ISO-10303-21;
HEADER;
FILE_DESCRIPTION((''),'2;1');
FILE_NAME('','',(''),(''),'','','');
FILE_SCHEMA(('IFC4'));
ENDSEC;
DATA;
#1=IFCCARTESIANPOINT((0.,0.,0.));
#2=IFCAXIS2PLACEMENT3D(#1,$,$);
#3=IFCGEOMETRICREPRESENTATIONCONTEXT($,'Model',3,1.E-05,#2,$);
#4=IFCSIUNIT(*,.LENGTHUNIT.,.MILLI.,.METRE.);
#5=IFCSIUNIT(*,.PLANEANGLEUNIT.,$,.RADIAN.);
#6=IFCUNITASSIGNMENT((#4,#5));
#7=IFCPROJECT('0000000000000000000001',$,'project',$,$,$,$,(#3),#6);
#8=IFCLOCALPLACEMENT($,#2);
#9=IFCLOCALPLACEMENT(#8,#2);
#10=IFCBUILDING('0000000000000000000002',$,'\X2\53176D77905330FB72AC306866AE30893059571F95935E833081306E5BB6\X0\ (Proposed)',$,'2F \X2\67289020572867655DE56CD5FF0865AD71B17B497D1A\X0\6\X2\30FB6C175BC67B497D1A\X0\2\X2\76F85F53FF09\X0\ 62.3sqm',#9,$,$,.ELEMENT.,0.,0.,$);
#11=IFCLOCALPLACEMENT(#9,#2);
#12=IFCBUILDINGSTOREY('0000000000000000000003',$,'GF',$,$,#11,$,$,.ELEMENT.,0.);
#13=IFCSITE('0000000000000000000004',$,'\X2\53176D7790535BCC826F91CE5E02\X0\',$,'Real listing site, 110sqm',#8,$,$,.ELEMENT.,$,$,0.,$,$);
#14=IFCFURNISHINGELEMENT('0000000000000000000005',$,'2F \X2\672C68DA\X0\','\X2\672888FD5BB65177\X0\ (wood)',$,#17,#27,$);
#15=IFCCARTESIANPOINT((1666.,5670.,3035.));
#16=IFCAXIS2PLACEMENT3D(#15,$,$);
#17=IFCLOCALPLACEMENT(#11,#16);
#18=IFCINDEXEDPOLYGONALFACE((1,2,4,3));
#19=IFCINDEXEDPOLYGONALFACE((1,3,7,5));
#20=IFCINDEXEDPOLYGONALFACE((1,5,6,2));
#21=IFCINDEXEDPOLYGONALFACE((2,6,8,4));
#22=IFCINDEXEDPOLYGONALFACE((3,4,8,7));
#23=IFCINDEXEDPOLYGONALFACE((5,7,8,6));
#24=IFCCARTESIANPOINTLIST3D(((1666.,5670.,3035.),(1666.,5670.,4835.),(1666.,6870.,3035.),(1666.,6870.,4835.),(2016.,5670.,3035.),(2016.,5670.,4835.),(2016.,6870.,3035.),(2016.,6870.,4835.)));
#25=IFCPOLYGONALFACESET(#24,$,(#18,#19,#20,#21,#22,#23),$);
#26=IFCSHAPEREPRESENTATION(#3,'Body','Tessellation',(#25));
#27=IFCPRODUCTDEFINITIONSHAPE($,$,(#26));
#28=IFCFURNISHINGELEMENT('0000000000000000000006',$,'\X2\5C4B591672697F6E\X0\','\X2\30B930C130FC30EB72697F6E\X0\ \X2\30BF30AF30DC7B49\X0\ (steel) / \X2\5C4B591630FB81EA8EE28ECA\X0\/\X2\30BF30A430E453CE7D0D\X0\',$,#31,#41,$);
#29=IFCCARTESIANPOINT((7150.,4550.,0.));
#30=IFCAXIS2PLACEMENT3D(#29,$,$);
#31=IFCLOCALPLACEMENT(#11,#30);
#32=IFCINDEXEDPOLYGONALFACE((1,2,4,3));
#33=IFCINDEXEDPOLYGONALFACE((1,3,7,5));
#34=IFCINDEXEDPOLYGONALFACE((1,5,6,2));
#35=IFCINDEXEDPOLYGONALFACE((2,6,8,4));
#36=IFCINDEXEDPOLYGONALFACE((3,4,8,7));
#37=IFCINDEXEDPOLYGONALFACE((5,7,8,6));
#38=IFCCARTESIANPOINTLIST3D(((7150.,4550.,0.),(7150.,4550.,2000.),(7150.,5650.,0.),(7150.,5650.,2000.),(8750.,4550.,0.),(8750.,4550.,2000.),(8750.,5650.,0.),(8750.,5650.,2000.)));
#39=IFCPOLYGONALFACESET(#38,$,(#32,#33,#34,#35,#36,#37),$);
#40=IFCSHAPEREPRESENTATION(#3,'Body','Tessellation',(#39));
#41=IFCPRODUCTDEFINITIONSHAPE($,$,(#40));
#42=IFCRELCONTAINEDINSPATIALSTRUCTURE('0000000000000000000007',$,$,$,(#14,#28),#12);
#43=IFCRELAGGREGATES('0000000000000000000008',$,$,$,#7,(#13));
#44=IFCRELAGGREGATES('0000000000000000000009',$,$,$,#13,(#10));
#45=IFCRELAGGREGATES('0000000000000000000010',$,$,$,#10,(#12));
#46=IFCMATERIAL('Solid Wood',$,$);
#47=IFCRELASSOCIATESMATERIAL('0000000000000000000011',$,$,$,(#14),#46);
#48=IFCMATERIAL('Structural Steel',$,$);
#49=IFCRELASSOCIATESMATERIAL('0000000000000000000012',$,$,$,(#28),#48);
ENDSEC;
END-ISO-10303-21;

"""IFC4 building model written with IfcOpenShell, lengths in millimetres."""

from ifc_helpers import new_model, si_unit, frame, frame_2d, origin, place, context, project, spatial, rectangle, extrude, material, element, save


model = new_model("IFC4")

# Units and contexts
model_context = context("Model", 3, precision=1e-05, world=origin())
ifc_project = project(units=[si_unit("LENGTHUNIT", "METRE", prefix="MILLI"), si_unit("PLANEANGLEUNIT", "RADIAN")], contexts=[model_context])

# Site, building, storey
site_placement = place(None, origin())
site = spatial("IfcSite", under=ifc_project, at=site_placement, Name="北海道富良野市", ObjectType="Real listing site, 110sqm", CompositionType="ELEMENT", RefElevation=0.0)
building_placement = place(site_placement, origin())
building = spatial("IfcBuilding", under=site, at=building_placement, Name="北海道・犬と暮らす土間広めの家 (Proposed)", ObjectType="2F 木造在来工法（断熱等級6・気密等級2相当） 62.3sqm", CompositionType="ELEMENT", ElevationOfRefHeight=0.0, ElevationOfTerrain=0.0)
storey_placement = place(building_placement, origin())
storey = spatial("IfcBuildingStorey", under=building, at=storey_placement, Name="GF", CompositionType="ELEMENT", Elevation=0.0)

# Shared definitions
ifc_material_1 = material(Name="Solid Wood")

# Shared definitions
ifc_material_2 = material(Name="Structural Steel")

# Furnishing elements
furnishing_1_placement = place(storey_placement, frame((1666.0, 5670.0, 3035.0)))
element("IfcFurnishingElement", 1, at=furnishing_1_placement, inside=storey, material=ifc_material_1, Name="2F 本棚", Description="木製家具 (wood)", context=model_context, shape_type="SweptSolid", body=[
    extrude(rectangle(XDim=350.0, YDim=1200.0, at=frame_2d((175.0, 600.0))), frame((1666.0, 5670.0, 3035.0)), (0.0, 0.0, 1.0), 1800.0),
])
furnishing_2_placement = place(storey_placement, frame((7150.0, 4550.0, 0.0)))
element("IfcFurnishingElement", 2, at=furnishing_2_placement, inside=storey, material=ifc_material_2, Name="屋外物置", Description="スチール物置 タクボ等 (steel) / 屋外・自転車/タイヤ収納", context=model_context, shape_type="SweptSolid", body=[
    extrude(rectangle(XDim=1600.0, YDim=1100.0, at=frame_2d((800.0, 550.0))), frame((7150.0, 4550.0, 0.0)), (0.0, 0.0, 1.0), 2000.0),
])

save(model, "model.ifc")
